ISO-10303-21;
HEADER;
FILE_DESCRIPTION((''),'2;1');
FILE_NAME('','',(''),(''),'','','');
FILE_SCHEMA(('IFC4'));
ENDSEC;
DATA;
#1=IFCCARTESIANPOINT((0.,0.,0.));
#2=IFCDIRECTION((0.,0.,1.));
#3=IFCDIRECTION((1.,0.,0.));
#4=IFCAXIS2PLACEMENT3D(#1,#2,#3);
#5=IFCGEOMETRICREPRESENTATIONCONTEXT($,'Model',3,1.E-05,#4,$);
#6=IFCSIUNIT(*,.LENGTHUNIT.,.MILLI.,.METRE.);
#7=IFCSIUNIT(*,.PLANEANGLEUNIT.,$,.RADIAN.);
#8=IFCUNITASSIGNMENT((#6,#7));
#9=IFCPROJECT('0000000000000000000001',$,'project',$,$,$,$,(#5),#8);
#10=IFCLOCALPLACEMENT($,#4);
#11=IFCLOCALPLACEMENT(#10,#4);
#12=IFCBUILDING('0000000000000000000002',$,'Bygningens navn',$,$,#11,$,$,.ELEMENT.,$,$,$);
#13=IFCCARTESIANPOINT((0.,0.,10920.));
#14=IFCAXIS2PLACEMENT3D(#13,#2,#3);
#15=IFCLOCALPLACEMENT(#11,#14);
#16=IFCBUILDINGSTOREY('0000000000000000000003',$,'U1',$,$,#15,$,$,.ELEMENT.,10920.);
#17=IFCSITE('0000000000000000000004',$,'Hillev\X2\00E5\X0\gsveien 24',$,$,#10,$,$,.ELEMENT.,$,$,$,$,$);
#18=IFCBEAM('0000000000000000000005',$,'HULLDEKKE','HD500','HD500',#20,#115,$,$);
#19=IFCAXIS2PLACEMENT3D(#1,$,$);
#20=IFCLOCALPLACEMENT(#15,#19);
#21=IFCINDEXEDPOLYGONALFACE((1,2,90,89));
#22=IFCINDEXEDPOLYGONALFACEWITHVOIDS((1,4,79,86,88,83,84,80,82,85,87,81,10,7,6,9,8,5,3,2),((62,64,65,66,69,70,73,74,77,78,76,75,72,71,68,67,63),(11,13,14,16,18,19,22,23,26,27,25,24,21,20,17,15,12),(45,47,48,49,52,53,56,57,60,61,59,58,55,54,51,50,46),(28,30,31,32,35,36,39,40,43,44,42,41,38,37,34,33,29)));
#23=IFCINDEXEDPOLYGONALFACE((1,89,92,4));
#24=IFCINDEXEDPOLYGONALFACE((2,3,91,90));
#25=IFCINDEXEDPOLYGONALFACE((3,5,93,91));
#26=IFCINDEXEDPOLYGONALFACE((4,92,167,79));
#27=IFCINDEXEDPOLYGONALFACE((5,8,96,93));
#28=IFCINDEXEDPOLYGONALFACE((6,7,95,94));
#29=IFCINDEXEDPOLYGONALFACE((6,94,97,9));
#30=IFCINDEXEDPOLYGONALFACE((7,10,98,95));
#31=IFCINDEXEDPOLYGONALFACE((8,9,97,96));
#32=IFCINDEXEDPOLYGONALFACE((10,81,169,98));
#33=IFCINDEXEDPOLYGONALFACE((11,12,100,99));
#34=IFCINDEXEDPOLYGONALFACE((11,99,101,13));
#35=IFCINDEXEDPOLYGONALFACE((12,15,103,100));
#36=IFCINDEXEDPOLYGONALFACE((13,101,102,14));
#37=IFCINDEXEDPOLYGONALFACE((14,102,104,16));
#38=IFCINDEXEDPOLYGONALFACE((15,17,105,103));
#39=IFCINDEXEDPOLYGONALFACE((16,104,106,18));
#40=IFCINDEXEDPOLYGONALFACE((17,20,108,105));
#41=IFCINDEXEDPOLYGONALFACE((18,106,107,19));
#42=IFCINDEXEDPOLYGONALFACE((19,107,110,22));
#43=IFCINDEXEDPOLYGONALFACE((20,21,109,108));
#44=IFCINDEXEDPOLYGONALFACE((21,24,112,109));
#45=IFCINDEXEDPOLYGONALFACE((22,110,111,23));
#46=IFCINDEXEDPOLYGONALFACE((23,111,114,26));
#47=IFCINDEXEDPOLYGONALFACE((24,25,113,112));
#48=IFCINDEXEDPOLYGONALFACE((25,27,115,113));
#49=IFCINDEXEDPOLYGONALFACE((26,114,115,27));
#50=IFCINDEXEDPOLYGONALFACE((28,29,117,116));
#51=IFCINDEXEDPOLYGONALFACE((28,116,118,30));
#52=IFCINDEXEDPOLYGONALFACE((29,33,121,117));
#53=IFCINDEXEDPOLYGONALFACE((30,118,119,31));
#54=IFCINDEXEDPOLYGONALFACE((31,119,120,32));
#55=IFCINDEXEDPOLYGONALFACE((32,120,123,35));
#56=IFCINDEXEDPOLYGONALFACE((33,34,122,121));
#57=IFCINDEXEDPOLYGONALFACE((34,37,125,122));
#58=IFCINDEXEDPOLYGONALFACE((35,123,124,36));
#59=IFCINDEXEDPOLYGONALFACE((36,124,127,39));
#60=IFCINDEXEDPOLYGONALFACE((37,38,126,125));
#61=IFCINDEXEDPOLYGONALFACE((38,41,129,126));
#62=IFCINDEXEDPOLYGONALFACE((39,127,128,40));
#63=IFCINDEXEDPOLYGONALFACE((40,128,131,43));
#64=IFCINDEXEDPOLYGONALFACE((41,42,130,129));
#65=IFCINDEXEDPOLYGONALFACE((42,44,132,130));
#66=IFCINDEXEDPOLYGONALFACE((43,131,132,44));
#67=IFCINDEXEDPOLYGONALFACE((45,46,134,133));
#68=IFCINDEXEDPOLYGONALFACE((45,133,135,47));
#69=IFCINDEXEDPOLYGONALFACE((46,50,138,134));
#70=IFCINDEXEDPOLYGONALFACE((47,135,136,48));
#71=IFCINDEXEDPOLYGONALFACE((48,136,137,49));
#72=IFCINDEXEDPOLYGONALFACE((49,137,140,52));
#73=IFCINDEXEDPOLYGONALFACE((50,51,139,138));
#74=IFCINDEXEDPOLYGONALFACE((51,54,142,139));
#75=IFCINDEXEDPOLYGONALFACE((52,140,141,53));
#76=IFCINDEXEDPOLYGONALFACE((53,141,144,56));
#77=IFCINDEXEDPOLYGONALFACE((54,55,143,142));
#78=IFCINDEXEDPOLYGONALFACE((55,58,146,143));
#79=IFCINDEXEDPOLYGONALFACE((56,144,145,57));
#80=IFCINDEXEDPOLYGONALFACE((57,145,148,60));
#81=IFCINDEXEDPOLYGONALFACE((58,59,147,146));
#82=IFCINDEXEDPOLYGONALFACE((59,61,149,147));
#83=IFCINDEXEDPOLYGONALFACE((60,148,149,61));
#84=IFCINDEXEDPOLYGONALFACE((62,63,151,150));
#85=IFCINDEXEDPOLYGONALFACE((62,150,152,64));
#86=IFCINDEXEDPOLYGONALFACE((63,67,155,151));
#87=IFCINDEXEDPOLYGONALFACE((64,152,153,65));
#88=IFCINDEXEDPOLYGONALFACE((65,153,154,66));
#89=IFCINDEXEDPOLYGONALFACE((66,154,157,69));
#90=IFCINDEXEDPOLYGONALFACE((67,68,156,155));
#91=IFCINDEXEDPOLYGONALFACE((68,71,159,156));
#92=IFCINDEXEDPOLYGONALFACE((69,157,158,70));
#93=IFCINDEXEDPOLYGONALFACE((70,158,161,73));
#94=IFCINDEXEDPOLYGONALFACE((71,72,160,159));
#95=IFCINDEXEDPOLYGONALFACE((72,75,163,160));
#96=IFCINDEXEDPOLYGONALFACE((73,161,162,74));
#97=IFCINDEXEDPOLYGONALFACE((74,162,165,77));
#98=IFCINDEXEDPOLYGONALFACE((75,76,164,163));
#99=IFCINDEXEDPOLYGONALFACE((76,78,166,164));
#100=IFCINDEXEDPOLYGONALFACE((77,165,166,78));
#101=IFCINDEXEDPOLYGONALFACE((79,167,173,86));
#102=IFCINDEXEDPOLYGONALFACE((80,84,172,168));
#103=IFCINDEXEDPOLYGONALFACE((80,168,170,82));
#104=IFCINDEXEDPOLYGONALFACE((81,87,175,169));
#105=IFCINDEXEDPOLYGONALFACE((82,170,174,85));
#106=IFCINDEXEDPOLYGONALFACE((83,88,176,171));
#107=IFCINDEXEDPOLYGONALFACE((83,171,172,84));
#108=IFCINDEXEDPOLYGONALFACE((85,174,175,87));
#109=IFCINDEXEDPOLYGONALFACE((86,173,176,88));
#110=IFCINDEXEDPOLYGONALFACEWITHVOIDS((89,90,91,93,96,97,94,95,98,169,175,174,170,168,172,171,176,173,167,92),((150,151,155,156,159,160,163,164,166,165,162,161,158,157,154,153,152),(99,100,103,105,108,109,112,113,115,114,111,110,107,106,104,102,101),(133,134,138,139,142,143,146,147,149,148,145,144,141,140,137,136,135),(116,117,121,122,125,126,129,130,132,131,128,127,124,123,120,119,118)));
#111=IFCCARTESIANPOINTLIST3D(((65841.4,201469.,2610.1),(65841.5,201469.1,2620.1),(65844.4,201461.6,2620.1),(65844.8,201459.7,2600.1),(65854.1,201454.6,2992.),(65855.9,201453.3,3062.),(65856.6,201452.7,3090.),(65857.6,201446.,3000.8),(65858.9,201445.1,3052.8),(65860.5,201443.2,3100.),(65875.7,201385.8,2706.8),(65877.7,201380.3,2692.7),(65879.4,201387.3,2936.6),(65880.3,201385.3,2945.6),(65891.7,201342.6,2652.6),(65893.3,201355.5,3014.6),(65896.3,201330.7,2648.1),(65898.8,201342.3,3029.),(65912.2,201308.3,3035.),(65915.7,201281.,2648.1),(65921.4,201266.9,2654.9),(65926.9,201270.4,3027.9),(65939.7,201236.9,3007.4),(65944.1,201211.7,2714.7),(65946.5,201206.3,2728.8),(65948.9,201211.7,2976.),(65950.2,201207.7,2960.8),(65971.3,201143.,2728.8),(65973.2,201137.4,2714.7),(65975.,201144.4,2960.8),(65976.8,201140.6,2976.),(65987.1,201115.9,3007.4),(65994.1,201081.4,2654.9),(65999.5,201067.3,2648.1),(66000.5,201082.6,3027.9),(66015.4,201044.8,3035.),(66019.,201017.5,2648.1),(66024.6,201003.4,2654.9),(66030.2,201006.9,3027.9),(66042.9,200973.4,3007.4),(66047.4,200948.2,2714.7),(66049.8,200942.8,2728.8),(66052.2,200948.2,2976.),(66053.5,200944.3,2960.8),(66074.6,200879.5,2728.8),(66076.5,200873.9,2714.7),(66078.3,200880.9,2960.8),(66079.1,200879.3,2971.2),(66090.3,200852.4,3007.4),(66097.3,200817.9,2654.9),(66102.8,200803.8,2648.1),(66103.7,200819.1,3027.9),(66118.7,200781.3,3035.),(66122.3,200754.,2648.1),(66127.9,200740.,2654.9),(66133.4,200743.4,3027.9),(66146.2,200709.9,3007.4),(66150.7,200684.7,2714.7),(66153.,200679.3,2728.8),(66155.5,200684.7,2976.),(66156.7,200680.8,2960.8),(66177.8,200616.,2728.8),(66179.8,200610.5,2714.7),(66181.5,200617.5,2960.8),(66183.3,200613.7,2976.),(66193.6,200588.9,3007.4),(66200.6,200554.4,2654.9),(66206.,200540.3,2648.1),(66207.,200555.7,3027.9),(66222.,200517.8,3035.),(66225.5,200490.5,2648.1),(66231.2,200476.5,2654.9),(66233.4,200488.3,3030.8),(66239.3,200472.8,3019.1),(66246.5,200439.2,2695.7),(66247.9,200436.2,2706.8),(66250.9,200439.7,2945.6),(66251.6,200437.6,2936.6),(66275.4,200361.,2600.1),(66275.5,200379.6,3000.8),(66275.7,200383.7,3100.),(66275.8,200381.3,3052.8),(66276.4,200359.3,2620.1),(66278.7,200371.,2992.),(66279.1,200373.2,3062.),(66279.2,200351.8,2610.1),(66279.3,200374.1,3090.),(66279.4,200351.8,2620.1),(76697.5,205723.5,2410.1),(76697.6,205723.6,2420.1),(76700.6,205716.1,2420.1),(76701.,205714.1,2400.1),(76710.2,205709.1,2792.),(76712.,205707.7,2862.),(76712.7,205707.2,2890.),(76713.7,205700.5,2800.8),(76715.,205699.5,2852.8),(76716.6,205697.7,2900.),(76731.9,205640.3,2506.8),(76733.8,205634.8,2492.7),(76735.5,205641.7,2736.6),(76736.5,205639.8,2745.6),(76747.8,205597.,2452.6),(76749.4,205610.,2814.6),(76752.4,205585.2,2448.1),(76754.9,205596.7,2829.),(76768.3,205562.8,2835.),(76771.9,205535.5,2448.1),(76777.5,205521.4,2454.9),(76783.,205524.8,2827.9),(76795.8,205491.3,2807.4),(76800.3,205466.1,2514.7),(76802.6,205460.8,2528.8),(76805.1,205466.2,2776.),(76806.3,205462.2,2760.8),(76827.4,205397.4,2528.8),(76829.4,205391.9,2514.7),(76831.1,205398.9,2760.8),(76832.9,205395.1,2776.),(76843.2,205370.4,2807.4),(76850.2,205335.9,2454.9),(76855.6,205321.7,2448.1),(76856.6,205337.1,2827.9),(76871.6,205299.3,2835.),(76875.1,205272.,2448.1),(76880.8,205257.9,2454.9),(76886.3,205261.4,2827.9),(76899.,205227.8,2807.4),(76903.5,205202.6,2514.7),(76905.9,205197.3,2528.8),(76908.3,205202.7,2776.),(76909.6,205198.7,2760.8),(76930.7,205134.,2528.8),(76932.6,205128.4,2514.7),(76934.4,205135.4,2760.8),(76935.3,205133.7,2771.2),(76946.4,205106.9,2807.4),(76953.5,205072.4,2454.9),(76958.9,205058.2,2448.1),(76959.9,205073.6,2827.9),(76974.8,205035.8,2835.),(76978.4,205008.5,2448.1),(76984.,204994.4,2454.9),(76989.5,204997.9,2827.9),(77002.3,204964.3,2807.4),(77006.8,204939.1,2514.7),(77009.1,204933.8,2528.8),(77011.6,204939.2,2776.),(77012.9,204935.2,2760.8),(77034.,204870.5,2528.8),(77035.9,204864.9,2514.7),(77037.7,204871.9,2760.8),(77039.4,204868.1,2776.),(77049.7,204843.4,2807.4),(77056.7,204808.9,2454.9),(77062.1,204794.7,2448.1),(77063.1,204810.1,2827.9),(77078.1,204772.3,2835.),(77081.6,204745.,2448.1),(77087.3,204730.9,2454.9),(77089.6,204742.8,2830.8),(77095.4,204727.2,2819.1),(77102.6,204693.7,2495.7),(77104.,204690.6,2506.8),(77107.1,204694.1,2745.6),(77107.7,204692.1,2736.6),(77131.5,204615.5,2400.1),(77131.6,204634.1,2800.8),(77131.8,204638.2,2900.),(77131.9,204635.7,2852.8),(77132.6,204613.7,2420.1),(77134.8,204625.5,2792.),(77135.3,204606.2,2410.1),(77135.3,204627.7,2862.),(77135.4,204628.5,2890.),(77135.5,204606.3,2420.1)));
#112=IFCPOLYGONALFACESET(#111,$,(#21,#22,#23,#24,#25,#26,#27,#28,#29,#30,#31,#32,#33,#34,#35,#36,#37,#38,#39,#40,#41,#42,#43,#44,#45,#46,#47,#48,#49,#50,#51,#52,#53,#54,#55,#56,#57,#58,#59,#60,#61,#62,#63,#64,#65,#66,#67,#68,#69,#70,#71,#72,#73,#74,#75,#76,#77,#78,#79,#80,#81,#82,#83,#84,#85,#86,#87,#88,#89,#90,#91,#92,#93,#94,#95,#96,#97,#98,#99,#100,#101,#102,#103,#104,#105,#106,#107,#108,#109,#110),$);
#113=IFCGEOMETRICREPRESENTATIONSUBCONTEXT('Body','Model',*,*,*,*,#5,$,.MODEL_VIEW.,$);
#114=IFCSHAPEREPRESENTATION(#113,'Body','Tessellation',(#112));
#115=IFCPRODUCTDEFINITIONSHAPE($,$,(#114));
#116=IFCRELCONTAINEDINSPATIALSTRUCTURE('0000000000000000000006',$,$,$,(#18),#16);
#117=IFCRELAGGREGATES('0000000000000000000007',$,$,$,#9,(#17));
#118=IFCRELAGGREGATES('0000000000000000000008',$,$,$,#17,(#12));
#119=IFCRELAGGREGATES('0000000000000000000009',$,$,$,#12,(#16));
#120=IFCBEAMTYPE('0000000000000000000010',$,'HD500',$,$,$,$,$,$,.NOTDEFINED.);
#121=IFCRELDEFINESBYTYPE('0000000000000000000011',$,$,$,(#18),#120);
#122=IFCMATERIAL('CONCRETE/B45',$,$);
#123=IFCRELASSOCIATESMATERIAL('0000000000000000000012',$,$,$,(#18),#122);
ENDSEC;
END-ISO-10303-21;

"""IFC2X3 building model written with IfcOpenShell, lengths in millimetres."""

from ifc_helpers import new_model, si_unit, frame, origin_with_axes, place, context, subcontext, project, spatial, polyline, outline, extrude, material, type_object, element, save


model = new_model("IFC2X3")

# Units and contexts
model_context = context("Model", 3, precision=1e-05, world=origin_with_axes())
body_context = subcontext(model_context, "Body", "Model", "MODEL_VIEW")
ifc_project = project(units=[si_unit("LENGTHUNIT", "METRE", prefix="MILLI"), si_unit("PLANEANGLEUNIT", "RADIAN")], contexts=[model_context])

# Site, building, storey
site_placement = place(None, origin_with_axes())
site = spatial("IfcSite", under=ifc_project, at=site_placement, Name="Hillevågsveien 24", CompositionType="ELEMENT")
building_placement = place(site_placement, origin_with_axes())
building = spatial("IfcBuilding", under=site, at=building_placement, Name="Bygningens navn", CompositionType="ELEMENT")
storey_placement = place(building_placement, frame((0.0, 0.0, 10920.0), z_axis=(0.0, 0.0, 1.0), x_axis=(1.0, 0.0, 0.0)))
storey = spatial("IfcBuildingStorey", under=building, at=storey_placement, Name="U1", CompositionType="ELEMENT", Elevation=10920.0)

# Beam
ifc_material_1 = material(Name="CONCRETE/B45")
beam_type_1 = type_object("IfcBeamType", Name="HD500", PredefinedType="NOTDEFINED")
beam_1_placement = place(storey_placement, frame((66064.1, 200911.9, 2850.0), z_axis=(0.015968, 0.006258, 0.999853), x_axis=(0.930919, 0.364823, -0.01715)))
element("IfcBeam", 1, at=beam_1_placement, inside=storey, type_object=beam_type_1, material=ifc_material_1, Name="HULLDEKKE", Description="HD500", ObjectType="HD500", context=body_context, shape_type="SweptSolid", body=[
    extrude(outline(polyline([(581.9, 142.0), (592.0, -230.0), (600.0, -230.0), (600.0, -240.0), (590.0, -250.0), (-590.0, -250.0), (-600.0, -240.0), (-600.0, -230.0), (-592.0, -230.0), (-581.9, 142.0), (-572.7, 150.7), (-571.3, 202.8), (-580.0, 212.0), (-579.3, 240.0), (-569.0, 250.0), (569.0, 250.0), (579.3, 240.0), (580.0, 212.0), (571.3, 202.8), (572.7, 150.7), (581.9, 142.0)]), holes=[polyline([(466.4, -195.1), (506.6, -154.3), (510.0, -143.2), (510.0, 86.5), (507.8, 95.6), (472.8, 169.1), (456.2, 180.7), (424.5, 185.0), (383.8, 177.9), (348.0, 157.4), (321.2, 126.0), (317.0, 110.8), (317.0, -121.2), (322.9, -135.4), (382.6, -195.1), (397.8, -202.0), (451.2, -202.0), (466.4, -195.1)]), polyline([(183.4, -195.1), (243.1, -135.4), (249.0, -121.2), (249.0, 110.8), (244.8, 126.0), (218.0, 157.4), (182.2, 177.9), (141.5, 185.0), (100.8, 177.9), (65.0, 157.4), (35.9, 121.2), (34.0, 110.8), (34.0, -121.2), (39.9, -135.4), (99.6, -195.1), (114.8, -202.0), (168.2, -202.0), (183.4, -195.1)]), polyline([(-99.6, -195.1), (-39.9, -135.4), (-34.0, -121.2), (-34.0, 110.8), (-38.2, 126.0), (-65.0, 157.4), (-100.8, 177.9), (-141.5, 185.0), (-182.2, 177.9), (-218.0, 157.4), (-244.8, 126.0), (-249.0, 110.8), (-249.0, -121.2), (-243.1, -135.4), (-183.4, -195.1), (-168.2, -202.0), (-114.8, -202.0), (-99.6, -195.1)]), polyline([(-382.6, -195.1), (-322.9, -135.4), (-317.0, -121.2), (-317.0, 110.8), (-321.2, 126.0), (-348.0, 157.4), (-383.8, 177.9), (-424.5, 185.0), (-461.0, 179.0), (-475.4, 164.6), (-507.9, 95.6), (-510.0, 86.5), (-510.0, -143.2), (-504.1, -157.4), (-463.9, -197.5), (-451.2, -202.0), (-397.8, -202.0), (-382.6, -195.1)])]), frame((11661.7, 0.0, 0.0), z_axis=(-1.0, 0.0, 0.0), x_axis=(0.0, -1.0, 0.0)), (0.0, 0.0, 1.0), 11661.7),
])

save(model, "model.ifc")
